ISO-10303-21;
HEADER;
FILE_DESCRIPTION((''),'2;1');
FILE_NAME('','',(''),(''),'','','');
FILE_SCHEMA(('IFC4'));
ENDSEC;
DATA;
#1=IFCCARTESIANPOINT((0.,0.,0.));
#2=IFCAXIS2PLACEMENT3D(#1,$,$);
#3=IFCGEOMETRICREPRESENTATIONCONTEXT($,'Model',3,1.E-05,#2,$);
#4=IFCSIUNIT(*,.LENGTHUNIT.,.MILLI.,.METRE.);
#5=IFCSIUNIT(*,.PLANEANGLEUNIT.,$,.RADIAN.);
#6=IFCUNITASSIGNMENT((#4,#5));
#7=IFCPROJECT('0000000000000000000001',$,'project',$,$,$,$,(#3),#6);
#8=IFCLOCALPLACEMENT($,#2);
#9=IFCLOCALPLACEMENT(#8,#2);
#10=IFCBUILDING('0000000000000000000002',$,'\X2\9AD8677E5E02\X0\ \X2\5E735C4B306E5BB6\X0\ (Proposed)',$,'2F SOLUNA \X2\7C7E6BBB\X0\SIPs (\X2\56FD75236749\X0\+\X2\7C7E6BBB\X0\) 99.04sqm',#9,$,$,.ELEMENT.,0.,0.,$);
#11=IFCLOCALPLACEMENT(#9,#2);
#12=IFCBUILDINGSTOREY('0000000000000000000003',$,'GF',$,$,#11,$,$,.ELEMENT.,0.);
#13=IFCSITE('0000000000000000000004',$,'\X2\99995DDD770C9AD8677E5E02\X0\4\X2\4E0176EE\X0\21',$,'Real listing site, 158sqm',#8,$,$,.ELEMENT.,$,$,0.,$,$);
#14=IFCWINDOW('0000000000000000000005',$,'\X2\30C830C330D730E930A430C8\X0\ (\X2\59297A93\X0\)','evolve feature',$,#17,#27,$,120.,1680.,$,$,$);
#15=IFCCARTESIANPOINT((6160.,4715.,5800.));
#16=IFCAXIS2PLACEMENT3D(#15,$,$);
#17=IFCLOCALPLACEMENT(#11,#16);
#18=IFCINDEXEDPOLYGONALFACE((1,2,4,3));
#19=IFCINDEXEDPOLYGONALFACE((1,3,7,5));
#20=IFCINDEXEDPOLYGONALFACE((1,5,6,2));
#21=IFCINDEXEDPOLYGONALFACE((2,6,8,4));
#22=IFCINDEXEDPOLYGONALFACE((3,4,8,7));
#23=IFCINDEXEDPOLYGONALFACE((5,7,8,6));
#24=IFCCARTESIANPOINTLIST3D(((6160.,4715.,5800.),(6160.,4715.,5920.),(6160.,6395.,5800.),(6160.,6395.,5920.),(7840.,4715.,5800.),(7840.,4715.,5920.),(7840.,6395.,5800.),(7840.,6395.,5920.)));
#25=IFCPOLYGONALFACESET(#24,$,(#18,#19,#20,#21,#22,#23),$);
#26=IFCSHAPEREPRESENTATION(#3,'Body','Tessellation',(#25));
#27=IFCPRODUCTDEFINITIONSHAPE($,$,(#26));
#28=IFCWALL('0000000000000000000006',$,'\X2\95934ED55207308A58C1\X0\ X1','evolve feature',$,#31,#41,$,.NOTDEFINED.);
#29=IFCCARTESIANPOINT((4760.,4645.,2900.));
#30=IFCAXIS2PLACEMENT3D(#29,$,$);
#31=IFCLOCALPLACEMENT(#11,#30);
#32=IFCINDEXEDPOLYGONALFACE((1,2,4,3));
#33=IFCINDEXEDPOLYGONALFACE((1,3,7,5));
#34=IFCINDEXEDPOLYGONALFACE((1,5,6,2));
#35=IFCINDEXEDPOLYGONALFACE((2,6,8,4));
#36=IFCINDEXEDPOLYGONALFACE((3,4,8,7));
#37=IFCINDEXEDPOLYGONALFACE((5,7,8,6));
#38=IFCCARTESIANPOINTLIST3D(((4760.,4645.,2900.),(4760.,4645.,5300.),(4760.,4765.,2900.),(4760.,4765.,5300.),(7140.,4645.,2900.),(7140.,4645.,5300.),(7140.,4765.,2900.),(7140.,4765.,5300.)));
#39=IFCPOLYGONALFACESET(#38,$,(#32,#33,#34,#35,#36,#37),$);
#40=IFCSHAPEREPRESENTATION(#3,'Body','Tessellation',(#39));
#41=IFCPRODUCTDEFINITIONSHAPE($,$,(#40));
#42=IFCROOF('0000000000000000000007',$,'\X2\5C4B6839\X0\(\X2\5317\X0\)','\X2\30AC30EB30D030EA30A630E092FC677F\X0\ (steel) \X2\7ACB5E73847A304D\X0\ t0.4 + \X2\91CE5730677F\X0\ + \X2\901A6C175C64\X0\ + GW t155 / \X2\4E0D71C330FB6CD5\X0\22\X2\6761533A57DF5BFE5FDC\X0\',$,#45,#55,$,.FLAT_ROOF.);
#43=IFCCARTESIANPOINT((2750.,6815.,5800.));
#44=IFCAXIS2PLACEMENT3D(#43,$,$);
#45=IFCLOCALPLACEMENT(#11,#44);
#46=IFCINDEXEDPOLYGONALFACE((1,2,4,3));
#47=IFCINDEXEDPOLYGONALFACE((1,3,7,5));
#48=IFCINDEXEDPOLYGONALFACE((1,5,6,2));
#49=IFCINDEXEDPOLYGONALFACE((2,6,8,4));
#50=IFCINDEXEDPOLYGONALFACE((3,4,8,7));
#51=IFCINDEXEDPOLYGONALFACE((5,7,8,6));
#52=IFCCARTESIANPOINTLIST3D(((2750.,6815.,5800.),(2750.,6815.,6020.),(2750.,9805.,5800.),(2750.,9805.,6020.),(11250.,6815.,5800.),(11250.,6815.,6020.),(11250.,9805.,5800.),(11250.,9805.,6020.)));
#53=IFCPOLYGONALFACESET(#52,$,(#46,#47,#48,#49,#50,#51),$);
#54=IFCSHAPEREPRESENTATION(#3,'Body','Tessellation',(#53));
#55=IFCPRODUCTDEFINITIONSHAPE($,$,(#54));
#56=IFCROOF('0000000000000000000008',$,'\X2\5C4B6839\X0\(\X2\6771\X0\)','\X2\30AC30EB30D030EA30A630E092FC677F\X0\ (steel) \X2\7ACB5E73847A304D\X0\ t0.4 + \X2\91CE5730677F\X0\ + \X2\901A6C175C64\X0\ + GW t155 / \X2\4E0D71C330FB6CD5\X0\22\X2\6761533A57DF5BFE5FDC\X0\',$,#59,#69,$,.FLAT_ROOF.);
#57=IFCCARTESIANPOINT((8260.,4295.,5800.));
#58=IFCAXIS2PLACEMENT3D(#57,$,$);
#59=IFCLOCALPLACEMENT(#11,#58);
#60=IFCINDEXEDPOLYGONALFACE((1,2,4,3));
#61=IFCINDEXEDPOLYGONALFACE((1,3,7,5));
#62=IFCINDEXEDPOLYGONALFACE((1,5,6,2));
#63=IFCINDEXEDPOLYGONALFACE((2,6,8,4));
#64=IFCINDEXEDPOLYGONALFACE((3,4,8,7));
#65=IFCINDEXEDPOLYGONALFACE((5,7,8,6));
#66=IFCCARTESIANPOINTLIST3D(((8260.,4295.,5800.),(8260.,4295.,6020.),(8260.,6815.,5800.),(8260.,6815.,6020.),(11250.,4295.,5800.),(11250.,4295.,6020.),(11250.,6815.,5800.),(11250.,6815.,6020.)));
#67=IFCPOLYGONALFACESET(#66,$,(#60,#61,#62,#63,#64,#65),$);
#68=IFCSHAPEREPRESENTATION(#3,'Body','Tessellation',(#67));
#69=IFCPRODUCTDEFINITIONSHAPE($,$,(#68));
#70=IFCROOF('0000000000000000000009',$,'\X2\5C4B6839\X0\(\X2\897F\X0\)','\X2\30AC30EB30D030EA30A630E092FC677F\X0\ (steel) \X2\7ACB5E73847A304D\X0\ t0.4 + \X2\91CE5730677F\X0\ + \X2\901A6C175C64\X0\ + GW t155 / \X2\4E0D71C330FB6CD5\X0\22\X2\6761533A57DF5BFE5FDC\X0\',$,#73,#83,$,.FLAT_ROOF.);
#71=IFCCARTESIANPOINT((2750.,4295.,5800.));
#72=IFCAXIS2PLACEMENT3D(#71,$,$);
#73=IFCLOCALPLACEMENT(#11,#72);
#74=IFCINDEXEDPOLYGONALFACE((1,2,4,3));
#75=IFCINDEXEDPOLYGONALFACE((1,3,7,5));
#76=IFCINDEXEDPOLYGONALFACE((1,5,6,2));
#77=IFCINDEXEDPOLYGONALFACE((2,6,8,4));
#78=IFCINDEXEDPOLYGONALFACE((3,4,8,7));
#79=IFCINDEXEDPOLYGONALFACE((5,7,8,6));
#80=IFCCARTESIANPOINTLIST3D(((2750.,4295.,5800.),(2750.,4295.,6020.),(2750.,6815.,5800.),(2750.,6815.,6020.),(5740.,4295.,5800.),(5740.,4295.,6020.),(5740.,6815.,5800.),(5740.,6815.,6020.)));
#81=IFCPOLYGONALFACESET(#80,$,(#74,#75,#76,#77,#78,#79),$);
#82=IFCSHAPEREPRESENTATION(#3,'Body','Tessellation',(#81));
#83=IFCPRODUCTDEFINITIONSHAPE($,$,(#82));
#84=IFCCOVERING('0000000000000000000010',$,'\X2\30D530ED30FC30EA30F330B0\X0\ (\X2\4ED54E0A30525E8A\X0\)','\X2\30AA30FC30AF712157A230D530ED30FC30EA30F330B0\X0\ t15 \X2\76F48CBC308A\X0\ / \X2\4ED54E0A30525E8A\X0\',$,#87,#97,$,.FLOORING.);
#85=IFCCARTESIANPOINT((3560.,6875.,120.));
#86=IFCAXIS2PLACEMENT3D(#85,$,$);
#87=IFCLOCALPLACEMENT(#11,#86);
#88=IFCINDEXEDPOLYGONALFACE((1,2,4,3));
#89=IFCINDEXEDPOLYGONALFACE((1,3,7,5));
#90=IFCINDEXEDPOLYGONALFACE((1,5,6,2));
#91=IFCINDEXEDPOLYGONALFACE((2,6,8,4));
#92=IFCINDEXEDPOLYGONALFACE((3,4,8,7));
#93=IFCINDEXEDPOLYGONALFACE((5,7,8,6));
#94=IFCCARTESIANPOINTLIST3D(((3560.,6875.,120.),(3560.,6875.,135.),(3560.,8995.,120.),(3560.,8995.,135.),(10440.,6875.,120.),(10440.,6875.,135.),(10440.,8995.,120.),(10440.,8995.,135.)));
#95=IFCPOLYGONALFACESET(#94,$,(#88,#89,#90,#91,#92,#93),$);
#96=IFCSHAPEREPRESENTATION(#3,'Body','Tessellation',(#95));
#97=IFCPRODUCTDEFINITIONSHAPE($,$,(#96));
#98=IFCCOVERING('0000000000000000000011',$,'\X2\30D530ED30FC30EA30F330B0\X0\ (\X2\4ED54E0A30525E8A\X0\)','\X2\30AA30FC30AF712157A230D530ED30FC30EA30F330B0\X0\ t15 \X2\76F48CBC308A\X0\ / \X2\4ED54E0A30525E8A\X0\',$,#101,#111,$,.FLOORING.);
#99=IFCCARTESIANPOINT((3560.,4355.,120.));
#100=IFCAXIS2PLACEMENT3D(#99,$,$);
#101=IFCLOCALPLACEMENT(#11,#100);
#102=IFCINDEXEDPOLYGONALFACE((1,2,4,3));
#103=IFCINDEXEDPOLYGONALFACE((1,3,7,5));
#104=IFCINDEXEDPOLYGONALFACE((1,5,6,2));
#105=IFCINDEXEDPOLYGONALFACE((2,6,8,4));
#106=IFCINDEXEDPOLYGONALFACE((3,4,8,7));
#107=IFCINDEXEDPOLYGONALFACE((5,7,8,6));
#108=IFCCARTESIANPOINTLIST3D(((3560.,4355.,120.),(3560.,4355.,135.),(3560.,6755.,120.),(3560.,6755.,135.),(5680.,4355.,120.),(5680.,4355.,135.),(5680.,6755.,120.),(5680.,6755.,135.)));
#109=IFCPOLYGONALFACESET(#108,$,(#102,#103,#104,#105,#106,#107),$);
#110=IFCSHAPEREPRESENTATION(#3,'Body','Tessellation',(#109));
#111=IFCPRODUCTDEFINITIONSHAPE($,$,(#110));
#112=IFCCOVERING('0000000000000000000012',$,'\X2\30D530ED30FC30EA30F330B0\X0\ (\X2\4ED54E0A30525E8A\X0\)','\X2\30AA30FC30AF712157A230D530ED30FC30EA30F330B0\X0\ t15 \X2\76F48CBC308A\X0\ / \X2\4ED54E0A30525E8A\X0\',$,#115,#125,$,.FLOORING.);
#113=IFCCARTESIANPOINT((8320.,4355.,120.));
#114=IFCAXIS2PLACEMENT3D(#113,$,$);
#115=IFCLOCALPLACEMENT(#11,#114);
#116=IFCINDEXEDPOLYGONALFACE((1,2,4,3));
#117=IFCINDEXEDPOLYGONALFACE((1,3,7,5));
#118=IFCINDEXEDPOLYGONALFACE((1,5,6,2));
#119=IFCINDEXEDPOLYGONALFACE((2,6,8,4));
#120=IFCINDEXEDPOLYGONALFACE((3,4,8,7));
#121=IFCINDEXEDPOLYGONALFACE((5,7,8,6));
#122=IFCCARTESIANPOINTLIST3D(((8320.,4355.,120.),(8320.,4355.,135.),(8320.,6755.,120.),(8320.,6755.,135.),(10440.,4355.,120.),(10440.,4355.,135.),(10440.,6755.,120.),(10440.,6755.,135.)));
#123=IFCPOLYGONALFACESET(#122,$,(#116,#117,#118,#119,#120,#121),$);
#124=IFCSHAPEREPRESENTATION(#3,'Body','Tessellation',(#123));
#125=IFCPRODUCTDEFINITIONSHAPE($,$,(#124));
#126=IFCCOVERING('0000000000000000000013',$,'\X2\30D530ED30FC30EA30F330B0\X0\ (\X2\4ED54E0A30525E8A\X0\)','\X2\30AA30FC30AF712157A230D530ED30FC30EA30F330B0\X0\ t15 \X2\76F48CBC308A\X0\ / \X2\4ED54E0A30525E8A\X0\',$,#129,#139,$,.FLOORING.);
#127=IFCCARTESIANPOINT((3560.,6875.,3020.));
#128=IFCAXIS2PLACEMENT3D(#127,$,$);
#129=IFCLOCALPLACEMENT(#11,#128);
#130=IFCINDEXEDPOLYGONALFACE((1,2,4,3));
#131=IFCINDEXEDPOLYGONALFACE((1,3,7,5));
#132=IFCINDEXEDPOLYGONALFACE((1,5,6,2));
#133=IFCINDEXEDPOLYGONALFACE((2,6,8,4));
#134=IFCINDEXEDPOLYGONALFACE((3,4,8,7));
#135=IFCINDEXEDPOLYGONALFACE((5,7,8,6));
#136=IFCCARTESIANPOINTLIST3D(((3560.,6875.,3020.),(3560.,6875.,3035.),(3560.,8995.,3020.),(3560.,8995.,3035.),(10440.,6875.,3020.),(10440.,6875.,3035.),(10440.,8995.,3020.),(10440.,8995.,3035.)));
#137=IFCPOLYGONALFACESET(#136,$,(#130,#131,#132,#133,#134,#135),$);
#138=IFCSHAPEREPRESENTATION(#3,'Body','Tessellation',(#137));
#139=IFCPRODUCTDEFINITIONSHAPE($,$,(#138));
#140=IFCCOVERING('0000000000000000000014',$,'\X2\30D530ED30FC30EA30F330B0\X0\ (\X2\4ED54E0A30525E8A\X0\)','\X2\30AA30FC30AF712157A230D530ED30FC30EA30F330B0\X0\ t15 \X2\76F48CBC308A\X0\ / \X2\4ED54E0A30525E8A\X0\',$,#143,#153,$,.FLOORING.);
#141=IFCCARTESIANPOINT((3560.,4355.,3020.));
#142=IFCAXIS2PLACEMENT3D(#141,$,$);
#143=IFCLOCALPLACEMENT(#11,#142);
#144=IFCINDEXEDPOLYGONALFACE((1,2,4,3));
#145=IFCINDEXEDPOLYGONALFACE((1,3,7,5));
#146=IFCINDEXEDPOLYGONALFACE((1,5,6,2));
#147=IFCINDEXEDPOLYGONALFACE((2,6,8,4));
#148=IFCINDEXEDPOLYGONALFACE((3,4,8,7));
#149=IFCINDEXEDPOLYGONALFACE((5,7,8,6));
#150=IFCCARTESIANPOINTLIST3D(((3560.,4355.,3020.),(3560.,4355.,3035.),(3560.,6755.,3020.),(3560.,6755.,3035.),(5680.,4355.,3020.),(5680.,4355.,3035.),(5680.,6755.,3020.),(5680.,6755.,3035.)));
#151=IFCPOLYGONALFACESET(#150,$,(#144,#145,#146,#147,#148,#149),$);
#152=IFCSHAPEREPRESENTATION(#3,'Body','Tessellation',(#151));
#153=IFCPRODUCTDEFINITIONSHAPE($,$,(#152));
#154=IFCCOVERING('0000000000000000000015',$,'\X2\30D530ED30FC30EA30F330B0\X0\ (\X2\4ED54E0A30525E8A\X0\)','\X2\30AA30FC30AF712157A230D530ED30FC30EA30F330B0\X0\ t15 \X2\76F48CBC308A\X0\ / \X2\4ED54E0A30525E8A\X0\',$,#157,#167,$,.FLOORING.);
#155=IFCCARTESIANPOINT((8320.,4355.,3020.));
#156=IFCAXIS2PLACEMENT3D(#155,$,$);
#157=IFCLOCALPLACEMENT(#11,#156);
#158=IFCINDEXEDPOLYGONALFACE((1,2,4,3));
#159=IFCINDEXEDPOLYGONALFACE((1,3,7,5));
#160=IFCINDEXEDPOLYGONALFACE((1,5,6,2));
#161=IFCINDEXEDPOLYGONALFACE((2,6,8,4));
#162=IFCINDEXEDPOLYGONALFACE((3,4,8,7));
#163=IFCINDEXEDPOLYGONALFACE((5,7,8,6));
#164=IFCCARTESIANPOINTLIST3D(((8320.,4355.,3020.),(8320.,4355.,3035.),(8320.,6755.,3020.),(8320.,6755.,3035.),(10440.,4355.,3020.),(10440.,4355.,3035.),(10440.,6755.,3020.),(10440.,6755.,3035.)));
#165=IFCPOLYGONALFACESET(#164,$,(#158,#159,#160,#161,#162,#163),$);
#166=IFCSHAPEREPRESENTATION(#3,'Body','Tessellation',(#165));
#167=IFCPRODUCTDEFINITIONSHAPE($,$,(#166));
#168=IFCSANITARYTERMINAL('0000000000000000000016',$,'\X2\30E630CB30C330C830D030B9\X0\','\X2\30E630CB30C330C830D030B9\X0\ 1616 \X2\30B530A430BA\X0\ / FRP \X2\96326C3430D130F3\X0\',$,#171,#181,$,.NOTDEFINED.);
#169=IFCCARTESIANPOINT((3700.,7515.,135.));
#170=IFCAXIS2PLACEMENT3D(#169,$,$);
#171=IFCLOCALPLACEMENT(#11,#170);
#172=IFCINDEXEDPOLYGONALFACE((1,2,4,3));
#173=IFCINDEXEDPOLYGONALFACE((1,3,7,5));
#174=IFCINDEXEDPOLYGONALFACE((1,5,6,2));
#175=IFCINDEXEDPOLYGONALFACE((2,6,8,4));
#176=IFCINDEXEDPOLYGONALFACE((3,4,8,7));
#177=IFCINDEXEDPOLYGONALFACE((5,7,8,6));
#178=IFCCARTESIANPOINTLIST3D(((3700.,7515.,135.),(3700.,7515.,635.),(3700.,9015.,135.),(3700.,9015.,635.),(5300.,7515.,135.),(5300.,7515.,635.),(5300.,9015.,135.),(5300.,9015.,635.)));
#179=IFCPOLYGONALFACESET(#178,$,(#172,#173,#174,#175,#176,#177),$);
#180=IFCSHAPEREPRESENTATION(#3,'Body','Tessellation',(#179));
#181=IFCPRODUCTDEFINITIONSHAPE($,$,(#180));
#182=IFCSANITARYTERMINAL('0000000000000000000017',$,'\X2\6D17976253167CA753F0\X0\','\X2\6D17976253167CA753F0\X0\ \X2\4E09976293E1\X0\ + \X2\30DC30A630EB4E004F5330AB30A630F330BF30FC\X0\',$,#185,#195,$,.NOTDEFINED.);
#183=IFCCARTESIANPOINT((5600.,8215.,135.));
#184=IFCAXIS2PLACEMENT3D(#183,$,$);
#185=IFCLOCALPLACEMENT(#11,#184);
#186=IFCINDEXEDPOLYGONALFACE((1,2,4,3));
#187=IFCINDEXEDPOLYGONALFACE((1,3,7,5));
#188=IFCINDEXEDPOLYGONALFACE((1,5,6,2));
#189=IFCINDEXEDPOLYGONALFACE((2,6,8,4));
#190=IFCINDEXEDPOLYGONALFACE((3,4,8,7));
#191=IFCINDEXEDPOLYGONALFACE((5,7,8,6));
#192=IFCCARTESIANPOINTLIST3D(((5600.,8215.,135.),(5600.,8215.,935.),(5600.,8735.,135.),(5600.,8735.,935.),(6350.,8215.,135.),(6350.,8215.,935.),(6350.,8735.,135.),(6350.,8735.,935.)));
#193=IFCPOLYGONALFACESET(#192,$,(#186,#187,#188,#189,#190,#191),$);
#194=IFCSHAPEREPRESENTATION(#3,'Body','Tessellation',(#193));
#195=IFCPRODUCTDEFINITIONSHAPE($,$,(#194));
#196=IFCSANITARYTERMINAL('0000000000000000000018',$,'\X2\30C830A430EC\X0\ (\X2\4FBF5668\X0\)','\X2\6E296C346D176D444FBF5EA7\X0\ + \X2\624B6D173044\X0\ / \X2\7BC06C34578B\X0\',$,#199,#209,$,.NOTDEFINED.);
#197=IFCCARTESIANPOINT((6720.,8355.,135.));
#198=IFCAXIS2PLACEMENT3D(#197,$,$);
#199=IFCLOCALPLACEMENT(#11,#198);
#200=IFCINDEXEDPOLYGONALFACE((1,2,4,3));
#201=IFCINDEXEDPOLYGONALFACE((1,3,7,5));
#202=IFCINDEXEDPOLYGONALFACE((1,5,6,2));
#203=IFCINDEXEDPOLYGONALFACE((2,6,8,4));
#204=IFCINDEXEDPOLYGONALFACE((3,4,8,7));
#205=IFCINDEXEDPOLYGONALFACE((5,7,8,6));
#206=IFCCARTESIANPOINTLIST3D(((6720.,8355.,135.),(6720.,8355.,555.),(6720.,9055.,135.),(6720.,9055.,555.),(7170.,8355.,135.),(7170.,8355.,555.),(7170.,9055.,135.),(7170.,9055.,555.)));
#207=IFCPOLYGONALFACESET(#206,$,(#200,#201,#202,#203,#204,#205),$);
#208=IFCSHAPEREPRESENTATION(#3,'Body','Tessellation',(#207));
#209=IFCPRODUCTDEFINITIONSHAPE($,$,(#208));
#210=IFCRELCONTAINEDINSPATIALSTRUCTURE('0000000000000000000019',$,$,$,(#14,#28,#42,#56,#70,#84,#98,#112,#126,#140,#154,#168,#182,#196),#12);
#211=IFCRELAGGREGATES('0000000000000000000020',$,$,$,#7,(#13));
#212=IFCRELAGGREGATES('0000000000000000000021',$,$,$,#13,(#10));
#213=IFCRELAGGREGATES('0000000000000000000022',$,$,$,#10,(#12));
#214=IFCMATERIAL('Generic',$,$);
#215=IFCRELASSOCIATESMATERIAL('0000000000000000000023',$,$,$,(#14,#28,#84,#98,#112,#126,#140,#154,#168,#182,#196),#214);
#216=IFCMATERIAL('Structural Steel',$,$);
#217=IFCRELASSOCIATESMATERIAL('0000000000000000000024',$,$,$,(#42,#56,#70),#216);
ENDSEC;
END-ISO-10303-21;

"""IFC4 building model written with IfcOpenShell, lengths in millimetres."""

from ifc_helpers import new_model, si_unit, frame, frame_2d, origin, place, context, project, spatial, rectangle, extrude, material, element, save


model = new_model("IFC4")

# Units and contexts
model_context = context("Model", 3, precision=1e-05, world=origin())
ifc_project = project(units=[si_unit("LENGTHUNIT", "METRE", prefix="MILLI"), si_unit("PLANEANGLEUNIT", "RADIAN")], contexts=[model_context])

# Site, building, storey
site_placement = place(None, origin())
site = spatial("IfcSite", under=ifc_project, at=site_placement, Name="香川県高松市4丁目21", ObjectType="Real listing site, 158sqm", CompositionType="ELEMENT", RefElevation=0.0)
building_placement = place(site_placement, origin())
building = spatial("IfcBuilding", under=site, at=building_placement, Name="高松市 平屋の家 (Proposed)", ObjectType="2F SOLUNA 籾殻SIPs (国産杉+籾殻) 99.04sqm", CompositionType="ELEMENT", ElevationOfRefHeight=0.0, ElevationOfTerrain=0.0)
storey_placement = place(building_placement, origin())
storey = spatial("IfcBuildingStorey", under=building, at=storey_placement, Name="GF", CompositionType="ELEMENT", Elevation=0.0)

# Window
ifc_material_1 = material(Name="Generic")
window_1_placement = place(storey_placement, frame((6160.0, 4715.0, 5800.0)))
element("IfcWindow", 1, at=window_1_placement, inside=storey, material=ifc_material_1, Name="トップライト (天窓)", Description="evolve feature", OverallHeight=120.0, OverallWidth=1680.0, context=model_context, shape_type="SweptSolid", body=[
    extrude(rectangle(XDim=1680.0, YDim=1680.0, at=frame_2d((840.0, 840.0))), frame((6160.0, 4715.0, 5800.0)), (0.0, 0.0, 1.0), 120.0),
])

# Wall
wall_1_placement = place(storey_placement, frame((4760.0, 4645.0, 2900.0)))
element("IfcWall", 2, at=wall_1_placement, inside=storey, material=ifc_material_1, Name="間仕切り壁 X1", Description="evolve feature", PredefinedType="NOTDEFINED", context=model_context, shape_type="SweptSolid", body=[
    extrude(rectangle(XDim=2380.0, YDim=120.0, at=frame_2d((1190.0, 60.0))), frame((4760.0, 4645.0, 2900.0)), (0.0, 0.0, 1.0), 2400.0),
])

# Roofs
ifc_material_2 = material(Name="Structural Steel")
roof_1_placement = place(storey_placement, frame((2750.0, 6815.0, 5800.0)))
element("IfcRoof", 3, at=roof_1_placement, inside=storey, material=ifc_material_2, Name="屋根(北)", Description="ガルバリウム鋼板 (steel) 立平葺き t0.4 + 野地板 + 通気層 + GW t155 / 不燃・法22条区域対応", PredefinedType="FLAT_ROOF", context=model_context, shape_type="SweptSolid", body=[
    extrude(rectangle(XDim=8500.0, YDim=2990.0, at=frame_2d((4250.0, 1495.0))), frame((2750.0, 6815.0, 5800.0)), (0.0, 0.0, 1.0), 220.0),
])
roof_2_placement = place(storey_placement, frame((8260.0, 4295.0, 5800.0)))
element("IfcRoof", 4, at=roof_2_placement, inside=storey, material=ifc_material_2, Name="屋根(東)", Description="ガルバリウム鋼板 (steel) 立平葺き t0.4 + 野地板 + 通気層 + GW t155 / 不燃・法22条区域対応", PredefinedType="FLAT_ROOF", context=model_context, shape_type="SweptSolid", body=[
    extrude(rectangle(XDim=2990.0, YDim=2520.0, at=frame_2d((1495.0, 1260.0))), frame((8260.0, 4295.0, 5800.0)), (0.0, 0.0, 1.0), 220.0),
])
roof_3_placement = place(storey_placement, frame((2750.0, 4295.0, 5800.0)))
element("IfcRoof", 5, at=roof_3_placement, inside=storey, material=ifc_material_2, Name="屋根(西)", Description="ガルバリウム鋼板 (steel) 立平葺き t0.4 + 野地板 + 通気層 + GW t155 / 不燃・法22条区域対応", PredefinedType="FLAT_ROOF", context=model_context, shape_type="SweptSolid", body=[
    extrude(rectangle(XDim=2990.0, YDim=2520.0, at=frame_2d((1495.0, 1260.0))), frame((2750.0, 4295.0, 5800.0)), (0.0, 0.0, 1.0), 220.0),
])

# Coverings
covering_1_placement = place(storey_placement, frame((3560.0, 6875.0, 120.0)))
element("IfcCovering", 6, at=covering_1_placement, inside=storey, material=ifc_material_1, Name="フローリング (仕上げ床)", Description="オーク無垢フローリング t15 直貼り / 仕上げ床", PredefinedType="FLOORING", context=model_context, shape_type="SweptSolid", body=[
    extrude(rectangle(XDim=6880.0, YDim=2120.0, at=frame_2d((3440.0, 1060.0))), frame((3560.0, 6875.0, 120.0)), (0.0, 0.0, 1.0), 15.0),
])
covering_2_placement = place(storey_placement, frame((3560.0, 4355.0, 120.0)))
element("IfcCovering", 7, at=covering_2_placement, inside=storey, material=ifc_material_1, Name="フローリング (仕上げ床)", Description="オーク無垢フローリング t15 直貼り / 仕上げ床", PredefinedType="FLOORING", context=model_context, shape_type="SweptSolid", body=[
    extrude(rectangle(XDim=2120.0, YDim=2400.0, at=frame_2d((1060.0, 1200.0))), frame((3560.0, 4355.0, 120.0)), (0.0, 0.0, 1.0), 15.0),
])
covering_3_placement = place(storey_placement, frame((8320.0, 4355.0, 120.0)))
element("IfcCovering", 8, at=covering_3_placement, inside=storey, material=ifc_material_1, Name="フローリング (仕上げ床)", Description="オーク無垢フローリング t15 直貼り / 仕上げ床", PredefinedType="FLOORING", context=model_context, shape_type="SweptSolid", body=[
    extrude(rectangle(XDim=2120.0, YDim=2400.0, at=frame_2d((1060.0, 1200.0))), frame((8320.0, 4355.0, 120.0)), (0.0, 0.0, 1.0), 15.0),
])
covering_4_placement = place(storey_placement, frame((3560.0, 6875.0, 3020.0)))
element("IfcCovering", 9, at=covering_4_placement, inside=storey, material=ifc_material_1, Name="フローリング (仕上げ床)", Description="オーク無垢フローリング t15 直貼り / 仕上げ床", PredefinedType="FLOORING", context=model_context, shape_type="SweptSolid", body=[
    extrude(rectangle(XDim=6880.0, YDim=2120.0, at=frame_2d((3440.0, 1060.0))), frame((3560.0, 6875.0, 3020.0)), (0.0, 0.0, 1.0), 15.0),
])
covering_5_placement = place(storey_placement, frame((3560.0, 4355.0, 3020.0)))
element("IfcCovering", 10, at=covering_5_placement, inside=storey, material=ifc_material_1, Name="フローリング (仕上げ床)", Description="オーク無垢フローリング t15 直貼り / 仕上げ床", PredefinedType="FLOORING", context=model_context, shape_type="SweptSolid", body=[
    extrude(rectangle(XDim=2120.0, YDim=2400.0, at=frame_2d((1060.0, 1200.0))), frame((3560.0, 4355.0, 3020.0)), (0.0, 0.0, 1.0), 15.0),
])
covering_6_placement = place(storey_placement, frame((8320.0, 4355.0, 3020.0)))
element("IfcCovering", 11, at=covering_6_placement, inside=storey, material=ifc_material_1, Name="フローリング (仕上げ床)", Description="オーク無垢フローリング t15 直貼り / 仕上げ床", PredefinedType="FLOORING", context=model_context, shape_type="SweptSolid", body=[
    extrude(rectangle(XDim=2120.0, YDim=2400.0, at=frame_2d((1060.0, 1200.0))), frame((8320.0, 4355.0, 3020.0)), (0.0, 0.0, 1.0), 15.0),
])

# Sanitary terminals
sanitary_terminal_1_placement = place(storey_placement, frame((3700.0, 7515.0, 135.0)))
element("IfcSanitaryTerminal", 12, at=sanitary_terminal_1_placement, inside=storey, material=ifc_material_1, Name="ユニットバス", Description="ユニットバス 1616 サイズ / FRP 防水パン", PredefinedType="NOTDEFINED", context=model_context, shape_type="SweptSolid", body=[
    extrude(rectangle(XDim=1600.0, YDim=1500.0, at=frame_2d((800.0, 750.0))), frame((3700.0, 7515.0, 135.0)), (0.0, 0.0, 1.0), 500.0),
])
sanitary_terminal_2_placement = place(storey_placement, frame((5600.0, 8215.0, 135.0)))
element("IfcSanitaryTerminal", 13, at=sanitary_terminal_2_placement, inside=storey, material=ifc_material_1, Name="洗面化粧台", Description="洗面化粧台 三面鏡 + ボウル一体カウンター", PredefinedType="NOTDEFINED", context=model_context, shape_type="SweptSolid", body=[
    extrude(rectangle(XDim=750.0, YDim=520.0, at=frame_2d((375.0, 260.0))), frame((5600.0, 8215.0, 135.0)), (0.0, 0.0, 1.0), 800.0),
])
sanitary_terminal_3_placement = place(storey_placement, frame((6720.0, 8355.0, 135.0)))
element("IfcSanitaryTerminal", 14, at=sanitary_terminal_3_placement, inside=storey, material=ifc_material_1, Name="トイレ (便器)", Description="温水洗浄便座 + 手洗い / 節水型", PredefinedType="NOTDEFINED", context=model_context, shape_type="SweptSolid", body=[
    extrude(rectangle(XDim=450.0, YDim=700.0, at=frame_2d((225.0, 350.0))), frame((6720.0, 8355.0, 135.0)), (0.0, 0.0, 1.0), 420.0),
])

save(model, "model.ifc")
